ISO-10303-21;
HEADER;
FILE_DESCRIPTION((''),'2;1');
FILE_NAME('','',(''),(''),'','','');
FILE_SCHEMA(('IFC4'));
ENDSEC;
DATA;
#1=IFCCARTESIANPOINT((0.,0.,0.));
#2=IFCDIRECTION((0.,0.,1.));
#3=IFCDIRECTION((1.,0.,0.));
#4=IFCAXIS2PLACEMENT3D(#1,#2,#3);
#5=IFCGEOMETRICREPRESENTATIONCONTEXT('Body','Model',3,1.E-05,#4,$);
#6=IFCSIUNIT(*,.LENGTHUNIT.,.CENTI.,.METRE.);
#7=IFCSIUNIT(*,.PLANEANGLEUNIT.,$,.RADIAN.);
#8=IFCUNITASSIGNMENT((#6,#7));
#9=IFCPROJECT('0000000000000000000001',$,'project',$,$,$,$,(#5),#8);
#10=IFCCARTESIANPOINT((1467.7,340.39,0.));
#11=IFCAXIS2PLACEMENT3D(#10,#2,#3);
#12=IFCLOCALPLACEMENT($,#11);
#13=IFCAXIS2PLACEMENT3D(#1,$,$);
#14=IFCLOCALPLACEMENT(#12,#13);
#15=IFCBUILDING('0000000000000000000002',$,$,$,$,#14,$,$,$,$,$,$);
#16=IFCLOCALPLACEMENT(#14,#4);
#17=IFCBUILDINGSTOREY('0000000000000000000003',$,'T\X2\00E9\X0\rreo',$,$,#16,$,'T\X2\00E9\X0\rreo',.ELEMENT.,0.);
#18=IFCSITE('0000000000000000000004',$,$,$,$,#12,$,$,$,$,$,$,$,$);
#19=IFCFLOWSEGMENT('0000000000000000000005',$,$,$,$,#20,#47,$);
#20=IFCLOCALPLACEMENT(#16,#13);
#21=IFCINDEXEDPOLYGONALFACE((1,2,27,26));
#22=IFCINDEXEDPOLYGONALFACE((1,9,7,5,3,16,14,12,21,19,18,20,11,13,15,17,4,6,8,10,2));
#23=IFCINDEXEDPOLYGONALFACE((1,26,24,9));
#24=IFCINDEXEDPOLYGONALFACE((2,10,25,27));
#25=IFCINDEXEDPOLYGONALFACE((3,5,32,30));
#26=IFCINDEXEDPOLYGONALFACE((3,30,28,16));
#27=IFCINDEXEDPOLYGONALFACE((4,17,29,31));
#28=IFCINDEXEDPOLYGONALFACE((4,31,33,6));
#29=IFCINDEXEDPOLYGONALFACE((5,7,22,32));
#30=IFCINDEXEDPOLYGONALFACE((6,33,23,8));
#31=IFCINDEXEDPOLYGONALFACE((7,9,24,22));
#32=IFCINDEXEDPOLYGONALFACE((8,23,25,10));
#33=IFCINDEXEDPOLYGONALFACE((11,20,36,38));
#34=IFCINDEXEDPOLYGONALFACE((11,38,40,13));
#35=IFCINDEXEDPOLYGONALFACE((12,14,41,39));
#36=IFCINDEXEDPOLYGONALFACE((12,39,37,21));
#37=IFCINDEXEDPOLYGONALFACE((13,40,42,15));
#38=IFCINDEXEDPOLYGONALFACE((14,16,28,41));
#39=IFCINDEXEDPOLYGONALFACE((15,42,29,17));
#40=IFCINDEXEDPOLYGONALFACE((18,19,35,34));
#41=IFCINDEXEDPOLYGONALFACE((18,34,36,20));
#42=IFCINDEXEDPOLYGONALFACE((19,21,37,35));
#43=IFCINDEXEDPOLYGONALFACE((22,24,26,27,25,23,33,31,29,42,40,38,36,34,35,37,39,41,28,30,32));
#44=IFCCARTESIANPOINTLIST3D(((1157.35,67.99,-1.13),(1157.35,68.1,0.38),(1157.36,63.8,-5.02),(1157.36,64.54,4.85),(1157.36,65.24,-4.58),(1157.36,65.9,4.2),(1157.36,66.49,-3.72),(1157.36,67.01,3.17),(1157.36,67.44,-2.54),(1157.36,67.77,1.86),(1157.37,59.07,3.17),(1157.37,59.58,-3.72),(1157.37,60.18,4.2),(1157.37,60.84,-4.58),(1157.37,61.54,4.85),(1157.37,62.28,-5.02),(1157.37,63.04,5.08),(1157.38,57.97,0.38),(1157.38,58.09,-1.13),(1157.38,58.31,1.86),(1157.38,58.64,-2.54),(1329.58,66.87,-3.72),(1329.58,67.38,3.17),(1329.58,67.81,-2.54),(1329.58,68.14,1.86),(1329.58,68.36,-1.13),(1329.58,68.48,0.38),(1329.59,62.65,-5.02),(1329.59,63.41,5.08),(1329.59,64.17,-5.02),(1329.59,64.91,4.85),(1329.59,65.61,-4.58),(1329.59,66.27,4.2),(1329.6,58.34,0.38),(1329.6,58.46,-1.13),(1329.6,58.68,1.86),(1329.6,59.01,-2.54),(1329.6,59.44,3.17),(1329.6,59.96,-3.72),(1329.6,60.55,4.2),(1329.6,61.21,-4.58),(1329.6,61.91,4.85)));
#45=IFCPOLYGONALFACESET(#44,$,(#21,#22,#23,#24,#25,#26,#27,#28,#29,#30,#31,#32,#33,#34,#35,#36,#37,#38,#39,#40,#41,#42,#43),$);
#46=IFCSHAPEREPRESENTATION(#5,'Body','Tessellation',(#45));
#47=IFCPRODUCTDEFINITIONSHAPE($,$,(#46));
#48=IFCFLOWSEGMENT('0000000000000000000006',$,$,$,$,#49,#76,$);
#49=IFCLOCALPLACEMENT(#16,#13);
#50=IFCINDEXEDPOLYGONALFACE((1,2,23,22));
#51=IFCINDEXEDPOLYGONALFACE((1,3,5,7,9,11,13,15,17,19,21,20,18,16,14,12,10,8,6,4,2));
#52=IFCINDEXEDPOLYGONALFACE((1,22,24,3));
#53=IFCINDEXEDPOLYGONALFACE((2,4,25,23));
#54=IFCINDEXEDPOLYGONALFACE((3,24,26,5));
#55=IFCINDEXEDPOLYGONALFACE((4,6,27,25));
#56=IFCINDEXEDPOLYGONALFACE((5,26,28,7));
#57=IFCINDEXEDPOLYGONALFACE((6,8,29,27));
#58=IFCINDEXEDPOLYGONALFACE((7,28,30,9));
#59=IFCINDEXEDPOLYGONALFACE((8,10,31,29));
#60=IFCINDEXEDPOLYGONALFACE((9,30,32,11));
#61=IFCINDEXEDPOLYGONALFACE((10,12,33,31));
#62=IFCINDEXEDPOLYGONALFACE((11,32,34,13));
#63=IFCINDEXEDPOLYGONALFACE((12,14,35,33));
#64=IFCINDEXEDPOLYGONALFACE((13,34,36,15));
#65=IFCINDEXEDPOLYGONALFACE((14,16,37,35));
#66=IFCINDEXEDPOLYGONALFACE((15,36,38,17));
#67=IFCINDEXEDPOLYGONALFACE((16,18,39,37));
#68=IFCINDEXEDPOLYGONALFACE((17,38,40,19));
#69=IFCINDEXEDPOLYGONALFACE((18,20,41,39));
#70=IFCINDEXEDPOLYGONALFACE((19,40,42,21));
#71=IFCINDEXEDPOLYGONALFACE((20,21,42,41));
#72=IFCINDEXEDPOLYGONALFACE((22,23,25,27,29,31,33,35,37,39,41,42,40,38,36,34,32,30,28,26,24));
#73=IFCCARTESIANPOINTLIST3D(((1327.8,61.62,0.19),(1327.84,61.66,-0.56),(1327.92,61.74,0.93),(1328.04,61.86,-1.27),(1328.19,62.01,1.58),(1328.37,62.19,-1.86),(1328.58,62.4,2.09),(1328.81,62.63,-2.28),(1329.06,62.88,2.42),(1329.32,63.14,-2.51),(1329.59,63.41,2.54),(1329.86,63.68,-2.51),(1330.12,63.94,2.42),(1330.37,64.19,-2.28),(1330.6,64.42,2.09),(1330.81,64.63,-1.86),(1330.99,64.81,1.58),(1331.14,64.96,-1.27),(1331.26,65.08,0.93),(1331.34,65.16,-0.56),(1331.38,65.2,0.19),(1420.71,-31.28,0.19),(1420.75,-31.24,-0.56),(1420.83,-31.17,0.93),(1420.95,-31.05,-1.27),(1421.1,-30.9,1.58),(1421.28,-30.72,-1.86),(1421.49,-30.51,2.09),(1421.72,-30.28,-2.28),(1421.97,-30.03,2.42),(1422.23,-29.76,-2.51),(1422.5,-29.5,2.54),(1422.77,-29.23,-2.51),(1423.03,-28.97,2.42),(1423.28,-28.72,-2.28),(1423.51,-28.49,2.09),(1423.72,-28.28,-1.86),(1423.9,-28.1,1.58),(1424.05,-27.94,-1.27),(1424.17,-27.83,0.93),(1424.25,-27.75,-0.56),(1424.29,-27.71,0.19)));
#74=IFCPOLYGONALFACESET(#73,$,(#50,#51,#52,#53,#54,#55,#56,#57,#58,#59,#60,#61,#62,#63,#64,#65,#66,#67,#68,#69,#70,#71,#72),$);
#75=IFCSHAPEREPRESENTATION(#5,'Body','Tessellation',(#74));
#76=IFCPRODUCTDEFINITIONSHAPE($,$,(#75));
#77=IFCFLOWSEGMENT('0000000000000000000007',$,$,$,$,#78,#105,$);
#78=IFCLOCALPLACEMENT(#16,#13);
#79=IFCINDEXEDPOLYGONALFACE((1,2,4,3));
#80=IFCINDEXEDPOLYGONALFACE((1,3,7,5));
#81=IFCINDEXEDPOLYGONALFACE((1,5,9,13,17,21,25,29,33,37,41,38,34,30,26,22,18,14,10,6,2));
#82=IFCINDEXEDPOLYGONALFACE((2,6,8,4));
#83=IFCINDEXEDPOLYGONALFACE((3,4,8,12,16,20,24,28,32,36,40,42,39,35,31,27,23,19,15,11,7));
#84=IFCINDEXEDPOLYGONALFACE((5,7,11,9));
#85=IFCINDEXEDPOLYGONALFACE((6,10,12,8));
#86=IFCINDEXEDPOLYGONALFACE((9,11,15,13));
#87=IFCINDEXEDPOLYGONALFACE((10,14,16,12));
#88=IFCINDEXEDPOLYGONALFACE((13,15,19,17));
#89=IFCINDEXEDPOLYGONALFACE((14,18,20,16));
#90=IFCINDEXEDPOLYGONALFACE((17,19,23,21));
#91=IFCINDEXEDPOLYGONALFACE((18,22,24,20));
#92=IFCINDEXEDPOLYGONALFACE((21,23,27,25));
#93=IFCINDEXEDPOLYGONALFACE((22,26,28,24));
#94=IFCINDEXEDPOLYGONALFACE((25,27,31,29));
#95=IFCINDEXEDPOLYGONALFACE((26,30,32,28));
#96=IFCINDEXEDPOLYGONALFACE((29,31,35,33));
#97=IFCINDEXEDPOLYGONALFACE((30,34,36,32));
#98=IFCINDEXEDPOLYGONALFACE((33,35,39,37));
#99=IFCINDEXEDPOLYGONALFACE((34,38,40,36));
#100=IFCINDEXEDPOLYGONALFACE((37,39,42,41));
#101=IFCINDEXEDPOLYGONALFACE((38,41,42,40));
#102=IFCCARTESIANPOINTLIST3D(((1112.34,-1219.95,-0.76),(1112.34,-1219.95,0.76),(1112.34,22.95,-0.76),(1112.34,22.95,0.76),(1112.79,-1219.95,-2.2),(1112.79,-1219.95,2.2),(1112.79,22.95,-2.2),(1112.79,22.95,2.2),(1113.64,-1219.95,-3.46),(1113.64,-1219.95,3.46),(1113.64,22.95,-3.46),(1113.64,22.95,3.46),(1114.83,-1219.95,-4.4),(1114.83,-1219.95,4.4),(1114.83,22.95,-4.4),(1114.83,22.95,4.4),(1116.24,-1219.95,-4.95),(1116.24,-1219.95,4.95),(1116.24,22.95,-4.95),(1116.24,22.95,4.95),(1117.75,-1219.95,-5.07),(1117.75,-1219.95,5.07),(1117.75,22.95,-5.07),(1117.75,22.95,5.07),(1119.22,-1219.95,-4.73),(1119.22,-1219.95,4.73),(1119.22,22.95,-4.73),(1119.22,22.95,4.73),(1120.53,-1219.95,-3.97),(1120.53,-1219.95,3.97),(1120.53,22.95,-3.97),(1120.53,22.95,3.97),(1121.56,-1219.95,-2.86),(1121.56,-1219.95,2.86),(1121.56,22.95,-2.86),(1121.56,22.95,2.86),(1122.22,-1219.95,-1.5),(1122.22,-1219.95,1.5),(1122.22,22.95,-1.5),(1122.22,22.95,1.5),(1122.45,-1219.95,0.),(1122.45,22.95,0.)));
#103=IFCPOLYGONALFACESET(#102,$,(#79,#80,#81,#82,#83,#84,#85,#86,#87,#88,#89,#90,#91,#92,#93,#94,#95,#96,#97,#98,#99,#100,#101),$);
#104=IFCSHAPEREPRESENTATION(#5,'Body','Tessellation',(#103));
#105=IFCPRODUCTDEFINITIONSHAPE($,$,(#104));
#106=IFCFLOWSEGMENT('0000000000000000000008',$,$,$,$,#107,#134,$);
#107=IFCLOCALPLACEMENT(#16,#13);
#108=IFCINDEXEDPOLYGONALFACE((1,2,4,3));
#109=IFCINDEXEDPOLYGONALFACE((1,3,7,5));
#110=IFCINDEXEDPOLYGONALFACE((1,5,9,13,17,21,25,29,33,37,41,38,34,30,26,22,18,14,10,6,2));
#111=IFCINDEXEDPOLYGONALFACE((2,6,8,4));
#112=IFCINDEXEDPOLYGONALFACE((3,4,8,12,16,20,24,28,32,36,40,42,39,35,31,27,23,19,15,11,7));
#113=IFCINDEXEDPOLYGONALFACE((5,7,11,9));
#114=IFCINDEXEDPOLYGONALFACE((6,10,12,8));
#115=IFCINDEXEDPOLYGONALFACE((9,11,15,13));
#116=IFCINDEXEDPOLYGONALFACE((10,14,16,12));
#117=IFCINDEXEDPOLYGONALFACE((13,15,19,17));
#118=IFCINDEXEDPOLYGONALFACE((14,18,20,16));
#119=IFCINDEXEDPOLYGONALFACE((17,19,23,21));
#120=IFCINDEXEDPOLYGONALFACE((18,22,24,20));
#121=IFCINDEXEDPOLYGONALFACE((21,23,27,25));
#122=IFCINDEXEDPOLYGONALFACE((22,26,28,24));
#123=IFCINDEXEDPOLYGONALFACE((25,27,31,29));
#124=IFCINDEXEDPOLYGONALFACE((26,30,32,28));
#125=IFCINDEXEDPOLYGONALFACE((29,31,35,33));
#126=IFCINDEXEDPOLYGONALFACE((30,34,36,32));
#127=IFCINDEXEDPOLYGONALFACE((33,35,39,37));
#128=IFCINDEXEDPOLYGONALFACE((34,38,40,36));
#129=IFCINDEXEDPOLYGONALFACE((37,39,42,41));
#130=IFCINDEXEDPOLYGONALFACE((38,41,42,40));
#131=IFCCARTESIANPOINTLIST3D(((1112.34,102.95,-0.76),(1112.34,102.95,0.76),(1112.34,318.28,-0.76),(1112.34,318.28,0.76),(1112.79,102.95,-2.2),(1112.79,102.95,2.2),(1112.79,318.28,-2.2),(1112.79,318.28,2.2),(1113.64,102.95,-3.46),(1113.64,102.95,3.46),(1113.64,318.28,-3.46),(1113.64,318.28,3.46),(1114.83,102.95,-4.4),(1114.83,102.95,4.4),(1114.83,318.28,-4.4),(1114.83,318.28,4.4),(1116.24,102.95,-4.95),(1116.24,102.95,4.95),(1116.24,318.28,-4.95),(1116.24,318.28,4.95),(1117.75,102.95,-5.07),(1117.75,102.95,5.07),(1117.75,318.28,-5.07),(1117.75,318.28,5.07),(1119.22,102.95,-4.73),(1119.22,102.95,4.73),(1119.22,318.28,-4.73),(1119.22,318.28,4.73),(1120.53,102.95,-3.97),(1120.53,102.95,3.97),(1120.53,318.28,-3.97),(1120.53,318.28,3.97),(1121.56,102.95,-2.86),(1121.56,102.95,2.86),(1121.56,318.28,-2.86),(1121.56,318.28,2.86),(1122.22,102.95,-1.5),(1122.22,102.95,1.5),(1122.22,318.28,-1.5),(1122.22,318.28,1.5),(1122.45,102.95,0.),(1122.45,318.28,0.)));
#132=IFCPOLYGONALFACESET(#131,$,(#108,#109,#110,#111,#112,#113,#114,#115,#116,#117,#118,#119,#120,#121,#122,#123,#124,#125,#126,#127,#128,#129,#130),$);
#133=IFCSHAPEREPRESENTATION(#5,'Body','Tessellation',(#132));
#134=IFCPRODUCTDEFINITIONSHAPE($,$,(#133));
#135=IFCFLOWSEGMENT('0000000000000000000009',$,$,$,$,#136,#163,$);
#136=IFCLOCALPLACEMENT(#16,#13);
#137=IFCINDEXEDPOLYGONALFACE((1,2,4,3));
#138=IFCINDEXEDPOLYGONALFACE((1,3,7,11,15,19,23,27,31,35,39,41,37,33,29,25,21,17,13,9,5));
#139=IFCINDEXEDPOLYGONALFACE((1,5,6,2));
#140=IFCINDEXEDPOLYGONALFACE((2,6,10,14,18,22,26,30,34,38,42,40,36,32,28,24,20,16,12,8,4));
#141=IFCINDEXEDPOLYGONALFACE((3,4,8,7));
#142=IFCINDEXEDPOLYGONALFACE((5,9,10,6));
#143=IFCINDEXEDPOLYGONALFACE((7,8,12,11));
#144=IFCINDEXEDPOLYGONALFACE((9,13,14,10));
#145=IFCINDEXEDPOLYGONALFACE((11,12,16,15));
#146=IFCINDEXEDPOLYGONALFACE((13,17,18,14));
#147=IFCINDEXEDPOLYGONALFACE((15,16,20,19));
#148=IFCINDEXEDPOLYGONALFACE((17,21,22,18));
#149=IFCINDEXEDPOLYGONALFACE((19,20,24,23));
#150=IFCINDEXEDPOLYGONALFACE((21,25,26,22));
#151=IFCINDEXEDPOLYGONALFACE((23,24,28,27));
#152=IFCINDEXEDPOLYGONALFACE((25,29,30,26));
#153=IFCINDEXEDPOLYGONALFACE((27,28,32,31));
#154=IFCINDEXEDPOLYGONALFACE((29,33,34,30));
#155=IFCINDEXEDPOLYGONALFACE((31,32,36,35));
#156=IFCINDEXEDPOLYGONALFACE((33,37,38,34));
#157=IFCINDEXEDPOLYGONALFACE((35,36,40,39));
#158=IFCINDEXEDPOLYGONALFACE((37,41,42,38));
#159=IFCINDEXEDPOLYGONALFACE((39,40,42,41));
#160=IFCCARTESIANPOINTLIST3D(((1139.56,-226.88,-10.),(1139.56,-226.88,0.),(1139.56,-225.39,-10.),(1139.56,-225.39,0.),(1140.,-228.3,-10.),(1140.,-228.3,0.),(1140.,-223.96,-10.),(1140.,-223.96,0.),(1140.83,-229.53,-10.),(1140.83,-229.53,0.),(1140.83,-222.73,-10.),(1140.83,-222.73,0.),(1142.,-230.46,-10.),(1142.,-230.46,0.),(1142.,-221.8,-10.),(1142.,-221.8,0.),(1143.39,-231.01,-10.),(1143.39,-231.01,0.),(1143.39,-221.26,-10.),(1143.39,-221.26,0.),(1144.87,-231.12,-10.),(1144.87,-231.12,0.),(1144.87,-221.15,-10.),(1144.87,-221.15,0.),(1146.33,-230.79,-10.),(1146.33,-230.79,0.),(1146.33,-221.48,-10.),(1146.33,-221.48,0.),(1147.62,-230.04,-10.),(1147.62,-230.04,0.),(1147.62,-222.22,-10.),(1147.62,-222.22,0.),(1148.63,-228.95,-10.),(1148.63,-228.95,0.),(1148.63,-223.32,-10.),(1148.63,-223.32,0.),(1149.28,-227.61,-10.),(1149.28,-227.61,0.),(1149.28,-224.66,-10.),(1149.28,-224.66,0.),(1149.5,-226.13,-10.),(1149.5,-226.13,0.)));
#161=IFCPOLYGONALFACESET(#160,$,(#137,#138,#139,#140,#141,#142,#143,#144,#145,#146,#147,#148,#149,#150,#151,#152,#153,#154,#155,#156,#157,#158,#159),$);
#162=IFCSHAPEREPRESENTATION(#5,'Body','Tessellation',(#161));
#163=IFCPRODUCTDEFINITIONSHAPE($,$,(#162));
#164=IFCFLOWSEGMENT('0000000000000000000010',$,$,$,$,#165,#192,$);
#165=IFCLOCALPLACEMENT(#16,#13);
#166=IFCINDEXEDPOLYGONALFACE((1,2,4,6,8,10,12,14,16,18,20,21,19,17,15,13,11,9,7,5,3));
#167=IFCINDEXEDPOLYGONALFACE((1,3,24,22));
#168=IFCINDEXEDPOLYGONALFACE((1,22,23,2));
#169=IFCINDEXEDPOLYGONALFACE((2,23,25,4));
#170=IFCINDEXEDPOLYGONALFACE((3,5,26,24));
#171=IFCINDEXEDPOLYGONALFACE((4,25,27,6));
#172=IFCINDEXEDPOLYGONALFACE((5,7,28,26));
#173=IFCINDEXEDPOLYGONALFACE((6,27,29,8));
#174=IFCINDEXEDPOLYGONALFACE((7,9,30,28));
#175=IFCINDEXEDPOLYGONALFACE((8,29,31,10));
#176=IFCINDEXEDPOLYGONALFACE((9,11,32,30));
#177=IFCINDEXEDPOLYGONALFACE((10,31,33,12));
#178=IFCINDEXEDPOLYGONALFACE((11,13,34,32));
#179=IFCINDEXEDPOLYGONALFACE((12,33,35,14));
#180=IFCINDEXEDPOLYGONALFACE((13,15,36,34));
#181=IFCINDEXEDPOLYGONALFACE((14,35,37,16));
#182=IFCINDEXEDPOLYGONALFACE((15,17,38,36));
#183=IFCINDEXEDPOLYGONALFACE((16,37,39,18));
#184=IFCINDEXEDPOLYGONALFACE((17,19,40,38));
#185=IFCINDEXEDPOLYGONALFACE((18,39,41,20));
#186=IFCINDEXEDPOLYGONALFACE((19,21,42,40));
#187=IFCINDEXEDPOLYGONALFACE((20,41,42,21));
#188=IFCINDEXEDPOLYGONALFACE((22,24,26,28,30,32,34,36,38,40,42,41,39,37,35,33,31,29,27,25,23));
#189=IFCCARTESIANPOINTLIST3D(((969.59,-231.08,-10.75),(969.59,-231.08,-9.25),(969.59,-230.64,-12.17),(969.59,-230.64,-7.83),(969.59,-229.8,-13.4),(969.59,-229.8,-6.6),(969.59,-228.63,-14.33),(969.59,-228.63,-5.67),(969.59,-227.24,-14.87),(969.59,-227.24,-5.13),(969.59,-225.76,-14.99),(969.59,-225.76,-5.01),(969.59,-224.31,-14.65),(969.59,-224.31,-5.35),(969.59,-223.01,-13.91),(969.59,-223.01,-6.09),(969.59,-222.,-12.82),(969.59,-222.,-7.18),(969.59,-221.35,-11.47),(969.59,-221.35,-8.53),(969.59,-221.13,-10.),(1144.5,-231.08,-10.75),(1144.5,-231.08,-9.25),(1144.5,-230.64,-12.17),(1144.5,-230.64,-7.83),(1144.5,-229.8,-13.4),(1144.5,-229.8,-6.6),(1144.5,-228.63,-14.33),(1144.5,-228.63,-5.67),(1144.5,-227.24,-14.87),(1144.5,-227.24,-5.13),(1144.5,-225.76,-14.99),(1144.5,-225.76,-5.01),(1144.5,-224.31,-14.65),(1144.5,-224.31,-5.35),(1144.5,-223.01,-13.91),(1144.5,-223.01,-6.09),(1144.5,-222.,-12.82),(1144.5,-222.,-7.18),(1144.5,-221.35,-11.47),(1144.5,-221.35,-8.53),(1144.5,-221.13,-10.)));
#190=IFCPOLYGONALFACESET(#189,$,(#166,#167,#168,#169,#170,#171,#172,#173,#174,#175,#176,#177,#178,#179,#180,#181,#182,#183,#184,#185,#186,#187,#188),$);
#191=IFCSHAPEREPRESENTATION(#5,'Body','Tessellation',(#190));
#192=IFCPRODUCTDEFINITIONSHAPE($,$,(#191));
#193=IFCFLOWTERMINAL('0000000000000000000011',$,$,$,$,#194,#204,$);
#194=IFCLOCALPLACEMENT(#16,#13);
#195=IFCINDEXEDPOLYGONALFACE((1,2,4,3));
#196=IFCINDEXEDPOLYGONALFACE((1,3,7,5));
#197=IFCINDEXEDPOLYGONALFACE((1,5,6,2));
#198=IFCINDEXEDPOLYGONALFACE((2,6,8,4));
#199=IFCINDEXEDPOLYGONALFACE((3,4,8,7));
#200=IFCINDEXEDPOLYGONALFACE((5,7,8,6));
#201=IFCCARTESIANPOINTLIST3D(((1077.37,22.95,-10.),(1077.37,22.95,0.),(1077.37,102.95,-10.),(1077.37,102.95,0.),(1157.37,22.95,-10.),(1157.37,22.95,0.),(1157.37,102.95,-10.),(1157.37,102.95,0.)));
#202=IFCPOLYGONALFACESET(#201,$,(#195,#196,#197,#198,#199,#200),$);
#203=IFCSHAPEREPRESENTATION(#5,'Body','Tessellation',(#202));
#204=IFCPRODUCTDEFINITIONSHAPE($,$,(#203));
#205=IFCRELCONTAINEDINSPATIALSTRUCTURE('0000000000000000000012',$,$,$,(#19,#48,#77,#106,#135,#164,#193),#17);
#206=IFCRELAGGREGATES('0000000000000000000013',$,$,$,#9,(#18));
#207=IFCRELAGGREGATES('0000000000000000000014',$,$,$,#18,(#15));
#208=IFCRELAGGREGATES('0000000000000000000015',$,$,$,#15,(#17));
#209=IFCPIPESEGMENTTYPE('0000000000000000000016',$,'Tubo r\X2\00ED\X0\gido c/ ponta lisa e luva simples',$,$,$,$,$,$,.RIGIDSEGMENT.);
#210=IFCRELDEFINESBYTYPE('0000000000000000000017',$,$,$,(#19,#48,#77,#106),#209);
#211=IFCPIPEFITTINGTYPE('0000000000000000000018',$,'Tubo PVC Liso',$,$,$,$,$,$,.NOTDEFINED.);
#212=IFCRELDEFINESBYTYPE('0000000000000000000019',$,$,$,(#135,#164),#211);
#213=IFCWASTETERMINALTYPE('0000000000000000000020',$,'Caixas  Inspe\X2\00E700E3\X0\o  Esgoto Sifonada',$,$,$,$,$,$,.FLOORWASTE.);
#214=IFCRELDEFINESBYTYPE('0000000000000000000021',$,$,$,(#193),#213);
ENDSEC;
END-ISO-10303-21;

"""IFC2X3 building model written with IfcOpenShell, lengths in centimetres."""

from ifc_helpers import new_model, si_unit, frame, origin, origin_with_axes, origin_2d_with_axis, place, context, project, spatial, rectangle, circle, extrude, type_object, element, save


model = new_model("IFC2X3")

# Units and contexts
model_context = context("Model", 3, precision=1e-05, world=origin_with_axes(), identifier="Body")
ifc_project = project(units=[si_unit("LENGTHUNIT", "METRE", prefix="CENTI"), si_unit("PLANEANGLEUNIT", "RADIAN")], contexts=[model_context])

# Site, building, storey
site_placement = place(None, frame((1467.7, 340.39, 0.0), z_axis=(0.0, 0.0, 1.0), x_axis=(1.0, 0.0, 0.0)))
site = spatial("IfcSite", under=ifc_project, at=site_placement)
building_placement = place(site_placement, origin())
building = spatial("IfcBuilding", under=site, at=building_placement)
storey_placement = place(building_placement, origin_with_axes())
storey = spatial("IfcBuildingStorey", under=building, at=storey_placement, Name="Térreo", LongName="Térreo", CompositionType="ELEMENT", Elevation=0.0)

# Flow segments
pipe_segment_type_1 = type_object("IfcPipeSegmentType", Name="Tubo rígido c/ ponta lisa e luva simples", PredefinedType="RIGIDSEGMENT")
flow_segment_1_placement = place(storey_placement, frame((1243.48, 63.22, 5.08), z_axis=(0.0, 0.0, 1.0), x_axis=(1.0, 0.0, 0.0)))
element("IfcFlowSegment", 1, at=flow_segment_1_placement, inside=storey, type_object=pipe_segment_type_1, context=model_context, shape_type="SolidModel", body=[
    extrude(circle(Radius=5.08, at=origin_2d_with_axis()), frame((86.11, 0.19, -5.08), z_axis=(-1.0, -0.002157, 0.0), x_axis=(0.0, 0.0, 1.0)), (0.0, 0.0, 1.0), 172.23),
])
flow_segment_2_placement = place(storey_placement, frame((1376.05, 16.96, 2.54), z_axis=(0.0, 0.0, 1.0), x_axis=(1.0, 0.0, 0.0)))
element("IfcFlowSegment", 2, at=flow_segment_2_placement, inside=storey, type_object=pipe_segment_type_1, context=model_context, shape_type="SolidModel", body=[
    extrude(circle(Radius=2.54, at=origin_2d_with_axis()), frame((46.45, -46.45, -2.54), z_axis=(-0.707107, 0.707107, 0.0), x_axis=(0.0, 0.0, 1.0)), (0.0, 0.0, 1.0), 131.39),
])
flow_segment_3_placement = place(storey_placement, frame((1117.37, -598.5, 5.08), z_axis=(0.0, 0.0, 1.0), x_axis=(1.0, 0.0, 0.0)))
element("IfcFlowSegment", 3, at=flow_segment_3_placement, inside=storey, type_object=pipe_segment_type_1, context=model_context, shape_type="SolidModel", body=[
    extrude(circle(Radius=5.08, at=origin_2d_with_axis()), frame((0.0, -621.45, -5.08), z_axis=(0.0, 1.0, 0.0), x_axis=(1.0, 0.0, 0.0)), (0.0, 0.0, 1.0), 1242.9),
])
flow_segment_4_placement = place(storey_placement, frame((1117.37, 210.61, 5.08), z_axis=(0.0, 0.0, 1.0), x_axis=(1.0, 0.0, 0.0)))
element("IfcFlowSegment", 4, at=flow_segment_4_placement, inside=storey, type_object=pipe_segment_type_1, context=model_context, shape_type="SolidModel", body=[
    extrude(circle(Radius=5.08, at=origin_2d_with_axis()), frame((0.0, -107.66, -5.08), z_axis=(0.0, 1.0, 0.0), x_axis=(1.0, 0.0, 0.0)), (0.0, 0.0, 1.0), 215.32),
])
pipe_fitting_type = type_object("IfcPipeFittingType", Name="Tubo PVC Liso", PredefinedType="NOTDEFINED")
flow_segment_5_placement = place(storey_placement, frame((1144.5, -226.13, 0.0), z_axis=(0.0, 0.0, 1.0), x_axis=(1.0, 0.0, 0.0)))
element("IfcFlowSegment", 5, at=flow_segment_5_placement, inside=storey, type_object=pipe_fitting_type, context=model_context, shape_type="SolidModel", body=[
    extrude(circle(Radius=5.0, at=origin_2d_with_axis()), frame((0.0, 0.0, 0.0), z_axis=(0.0, 0.0, -1.0), x_axis=(1.0, 0.0, 0.0)), (0.0, 0.0, 1.0), 10.0),
])
flow_segment_6_placement = place(storey_placement, frame((1057.05, -226.13, -5.0), z_axis=(0.0, 0.0, 1.0), x_axis=(1.0, 0.0, 0.0)))
element("IfcFlowSegment", 6, at=flow_segment_6_placement, inside=storey, type_object=pipe_fitting_type, context=model_context, shape_type="SolidModel", body=[
    extrude(circle(Radius=5.0, at=origin_2d_with_axis()), frame((87.45, 0.0, -5.0), z_axis=(-1.0, 0.0, 0.0), x_axis=(0.0, 1.0, 0.0)), (0.0, 0.0, 1.0), 174.91),
])

# Flow terminal
waste_terminal_type_1 = type_object("IfcWasteTerminalType", Name="Caixas  Inspeção  Esgoto Sifonada", PredefinedType="FLOORWASTE")
flow_terminal_1_placement = place(storey_placement, frame((1117.37, 62.95, 0.0), z_axis=(0.0, 0.0, 1.0), x_axis=(1.0, 0.0, 0.0)))
element("IfcFlowTerminal", 7, at=flow_terminal_1_placement, inside=storey, type_object=waste_terminal_type_1, context=model_context, shape_type="SolidModel", body=[
    extrude(rectangle(XDim=80.0, YDim=80.0, at=origin_2d_with_axis()), frame((0.0, 0.0, -10.0), z_axis=(0.0, 0.0, 1.0), x_axis=(0.0, -1.0, 0.0)), (0.0, 0.0, 1.0), 10.0),
])

save(model, "model.ifc")
